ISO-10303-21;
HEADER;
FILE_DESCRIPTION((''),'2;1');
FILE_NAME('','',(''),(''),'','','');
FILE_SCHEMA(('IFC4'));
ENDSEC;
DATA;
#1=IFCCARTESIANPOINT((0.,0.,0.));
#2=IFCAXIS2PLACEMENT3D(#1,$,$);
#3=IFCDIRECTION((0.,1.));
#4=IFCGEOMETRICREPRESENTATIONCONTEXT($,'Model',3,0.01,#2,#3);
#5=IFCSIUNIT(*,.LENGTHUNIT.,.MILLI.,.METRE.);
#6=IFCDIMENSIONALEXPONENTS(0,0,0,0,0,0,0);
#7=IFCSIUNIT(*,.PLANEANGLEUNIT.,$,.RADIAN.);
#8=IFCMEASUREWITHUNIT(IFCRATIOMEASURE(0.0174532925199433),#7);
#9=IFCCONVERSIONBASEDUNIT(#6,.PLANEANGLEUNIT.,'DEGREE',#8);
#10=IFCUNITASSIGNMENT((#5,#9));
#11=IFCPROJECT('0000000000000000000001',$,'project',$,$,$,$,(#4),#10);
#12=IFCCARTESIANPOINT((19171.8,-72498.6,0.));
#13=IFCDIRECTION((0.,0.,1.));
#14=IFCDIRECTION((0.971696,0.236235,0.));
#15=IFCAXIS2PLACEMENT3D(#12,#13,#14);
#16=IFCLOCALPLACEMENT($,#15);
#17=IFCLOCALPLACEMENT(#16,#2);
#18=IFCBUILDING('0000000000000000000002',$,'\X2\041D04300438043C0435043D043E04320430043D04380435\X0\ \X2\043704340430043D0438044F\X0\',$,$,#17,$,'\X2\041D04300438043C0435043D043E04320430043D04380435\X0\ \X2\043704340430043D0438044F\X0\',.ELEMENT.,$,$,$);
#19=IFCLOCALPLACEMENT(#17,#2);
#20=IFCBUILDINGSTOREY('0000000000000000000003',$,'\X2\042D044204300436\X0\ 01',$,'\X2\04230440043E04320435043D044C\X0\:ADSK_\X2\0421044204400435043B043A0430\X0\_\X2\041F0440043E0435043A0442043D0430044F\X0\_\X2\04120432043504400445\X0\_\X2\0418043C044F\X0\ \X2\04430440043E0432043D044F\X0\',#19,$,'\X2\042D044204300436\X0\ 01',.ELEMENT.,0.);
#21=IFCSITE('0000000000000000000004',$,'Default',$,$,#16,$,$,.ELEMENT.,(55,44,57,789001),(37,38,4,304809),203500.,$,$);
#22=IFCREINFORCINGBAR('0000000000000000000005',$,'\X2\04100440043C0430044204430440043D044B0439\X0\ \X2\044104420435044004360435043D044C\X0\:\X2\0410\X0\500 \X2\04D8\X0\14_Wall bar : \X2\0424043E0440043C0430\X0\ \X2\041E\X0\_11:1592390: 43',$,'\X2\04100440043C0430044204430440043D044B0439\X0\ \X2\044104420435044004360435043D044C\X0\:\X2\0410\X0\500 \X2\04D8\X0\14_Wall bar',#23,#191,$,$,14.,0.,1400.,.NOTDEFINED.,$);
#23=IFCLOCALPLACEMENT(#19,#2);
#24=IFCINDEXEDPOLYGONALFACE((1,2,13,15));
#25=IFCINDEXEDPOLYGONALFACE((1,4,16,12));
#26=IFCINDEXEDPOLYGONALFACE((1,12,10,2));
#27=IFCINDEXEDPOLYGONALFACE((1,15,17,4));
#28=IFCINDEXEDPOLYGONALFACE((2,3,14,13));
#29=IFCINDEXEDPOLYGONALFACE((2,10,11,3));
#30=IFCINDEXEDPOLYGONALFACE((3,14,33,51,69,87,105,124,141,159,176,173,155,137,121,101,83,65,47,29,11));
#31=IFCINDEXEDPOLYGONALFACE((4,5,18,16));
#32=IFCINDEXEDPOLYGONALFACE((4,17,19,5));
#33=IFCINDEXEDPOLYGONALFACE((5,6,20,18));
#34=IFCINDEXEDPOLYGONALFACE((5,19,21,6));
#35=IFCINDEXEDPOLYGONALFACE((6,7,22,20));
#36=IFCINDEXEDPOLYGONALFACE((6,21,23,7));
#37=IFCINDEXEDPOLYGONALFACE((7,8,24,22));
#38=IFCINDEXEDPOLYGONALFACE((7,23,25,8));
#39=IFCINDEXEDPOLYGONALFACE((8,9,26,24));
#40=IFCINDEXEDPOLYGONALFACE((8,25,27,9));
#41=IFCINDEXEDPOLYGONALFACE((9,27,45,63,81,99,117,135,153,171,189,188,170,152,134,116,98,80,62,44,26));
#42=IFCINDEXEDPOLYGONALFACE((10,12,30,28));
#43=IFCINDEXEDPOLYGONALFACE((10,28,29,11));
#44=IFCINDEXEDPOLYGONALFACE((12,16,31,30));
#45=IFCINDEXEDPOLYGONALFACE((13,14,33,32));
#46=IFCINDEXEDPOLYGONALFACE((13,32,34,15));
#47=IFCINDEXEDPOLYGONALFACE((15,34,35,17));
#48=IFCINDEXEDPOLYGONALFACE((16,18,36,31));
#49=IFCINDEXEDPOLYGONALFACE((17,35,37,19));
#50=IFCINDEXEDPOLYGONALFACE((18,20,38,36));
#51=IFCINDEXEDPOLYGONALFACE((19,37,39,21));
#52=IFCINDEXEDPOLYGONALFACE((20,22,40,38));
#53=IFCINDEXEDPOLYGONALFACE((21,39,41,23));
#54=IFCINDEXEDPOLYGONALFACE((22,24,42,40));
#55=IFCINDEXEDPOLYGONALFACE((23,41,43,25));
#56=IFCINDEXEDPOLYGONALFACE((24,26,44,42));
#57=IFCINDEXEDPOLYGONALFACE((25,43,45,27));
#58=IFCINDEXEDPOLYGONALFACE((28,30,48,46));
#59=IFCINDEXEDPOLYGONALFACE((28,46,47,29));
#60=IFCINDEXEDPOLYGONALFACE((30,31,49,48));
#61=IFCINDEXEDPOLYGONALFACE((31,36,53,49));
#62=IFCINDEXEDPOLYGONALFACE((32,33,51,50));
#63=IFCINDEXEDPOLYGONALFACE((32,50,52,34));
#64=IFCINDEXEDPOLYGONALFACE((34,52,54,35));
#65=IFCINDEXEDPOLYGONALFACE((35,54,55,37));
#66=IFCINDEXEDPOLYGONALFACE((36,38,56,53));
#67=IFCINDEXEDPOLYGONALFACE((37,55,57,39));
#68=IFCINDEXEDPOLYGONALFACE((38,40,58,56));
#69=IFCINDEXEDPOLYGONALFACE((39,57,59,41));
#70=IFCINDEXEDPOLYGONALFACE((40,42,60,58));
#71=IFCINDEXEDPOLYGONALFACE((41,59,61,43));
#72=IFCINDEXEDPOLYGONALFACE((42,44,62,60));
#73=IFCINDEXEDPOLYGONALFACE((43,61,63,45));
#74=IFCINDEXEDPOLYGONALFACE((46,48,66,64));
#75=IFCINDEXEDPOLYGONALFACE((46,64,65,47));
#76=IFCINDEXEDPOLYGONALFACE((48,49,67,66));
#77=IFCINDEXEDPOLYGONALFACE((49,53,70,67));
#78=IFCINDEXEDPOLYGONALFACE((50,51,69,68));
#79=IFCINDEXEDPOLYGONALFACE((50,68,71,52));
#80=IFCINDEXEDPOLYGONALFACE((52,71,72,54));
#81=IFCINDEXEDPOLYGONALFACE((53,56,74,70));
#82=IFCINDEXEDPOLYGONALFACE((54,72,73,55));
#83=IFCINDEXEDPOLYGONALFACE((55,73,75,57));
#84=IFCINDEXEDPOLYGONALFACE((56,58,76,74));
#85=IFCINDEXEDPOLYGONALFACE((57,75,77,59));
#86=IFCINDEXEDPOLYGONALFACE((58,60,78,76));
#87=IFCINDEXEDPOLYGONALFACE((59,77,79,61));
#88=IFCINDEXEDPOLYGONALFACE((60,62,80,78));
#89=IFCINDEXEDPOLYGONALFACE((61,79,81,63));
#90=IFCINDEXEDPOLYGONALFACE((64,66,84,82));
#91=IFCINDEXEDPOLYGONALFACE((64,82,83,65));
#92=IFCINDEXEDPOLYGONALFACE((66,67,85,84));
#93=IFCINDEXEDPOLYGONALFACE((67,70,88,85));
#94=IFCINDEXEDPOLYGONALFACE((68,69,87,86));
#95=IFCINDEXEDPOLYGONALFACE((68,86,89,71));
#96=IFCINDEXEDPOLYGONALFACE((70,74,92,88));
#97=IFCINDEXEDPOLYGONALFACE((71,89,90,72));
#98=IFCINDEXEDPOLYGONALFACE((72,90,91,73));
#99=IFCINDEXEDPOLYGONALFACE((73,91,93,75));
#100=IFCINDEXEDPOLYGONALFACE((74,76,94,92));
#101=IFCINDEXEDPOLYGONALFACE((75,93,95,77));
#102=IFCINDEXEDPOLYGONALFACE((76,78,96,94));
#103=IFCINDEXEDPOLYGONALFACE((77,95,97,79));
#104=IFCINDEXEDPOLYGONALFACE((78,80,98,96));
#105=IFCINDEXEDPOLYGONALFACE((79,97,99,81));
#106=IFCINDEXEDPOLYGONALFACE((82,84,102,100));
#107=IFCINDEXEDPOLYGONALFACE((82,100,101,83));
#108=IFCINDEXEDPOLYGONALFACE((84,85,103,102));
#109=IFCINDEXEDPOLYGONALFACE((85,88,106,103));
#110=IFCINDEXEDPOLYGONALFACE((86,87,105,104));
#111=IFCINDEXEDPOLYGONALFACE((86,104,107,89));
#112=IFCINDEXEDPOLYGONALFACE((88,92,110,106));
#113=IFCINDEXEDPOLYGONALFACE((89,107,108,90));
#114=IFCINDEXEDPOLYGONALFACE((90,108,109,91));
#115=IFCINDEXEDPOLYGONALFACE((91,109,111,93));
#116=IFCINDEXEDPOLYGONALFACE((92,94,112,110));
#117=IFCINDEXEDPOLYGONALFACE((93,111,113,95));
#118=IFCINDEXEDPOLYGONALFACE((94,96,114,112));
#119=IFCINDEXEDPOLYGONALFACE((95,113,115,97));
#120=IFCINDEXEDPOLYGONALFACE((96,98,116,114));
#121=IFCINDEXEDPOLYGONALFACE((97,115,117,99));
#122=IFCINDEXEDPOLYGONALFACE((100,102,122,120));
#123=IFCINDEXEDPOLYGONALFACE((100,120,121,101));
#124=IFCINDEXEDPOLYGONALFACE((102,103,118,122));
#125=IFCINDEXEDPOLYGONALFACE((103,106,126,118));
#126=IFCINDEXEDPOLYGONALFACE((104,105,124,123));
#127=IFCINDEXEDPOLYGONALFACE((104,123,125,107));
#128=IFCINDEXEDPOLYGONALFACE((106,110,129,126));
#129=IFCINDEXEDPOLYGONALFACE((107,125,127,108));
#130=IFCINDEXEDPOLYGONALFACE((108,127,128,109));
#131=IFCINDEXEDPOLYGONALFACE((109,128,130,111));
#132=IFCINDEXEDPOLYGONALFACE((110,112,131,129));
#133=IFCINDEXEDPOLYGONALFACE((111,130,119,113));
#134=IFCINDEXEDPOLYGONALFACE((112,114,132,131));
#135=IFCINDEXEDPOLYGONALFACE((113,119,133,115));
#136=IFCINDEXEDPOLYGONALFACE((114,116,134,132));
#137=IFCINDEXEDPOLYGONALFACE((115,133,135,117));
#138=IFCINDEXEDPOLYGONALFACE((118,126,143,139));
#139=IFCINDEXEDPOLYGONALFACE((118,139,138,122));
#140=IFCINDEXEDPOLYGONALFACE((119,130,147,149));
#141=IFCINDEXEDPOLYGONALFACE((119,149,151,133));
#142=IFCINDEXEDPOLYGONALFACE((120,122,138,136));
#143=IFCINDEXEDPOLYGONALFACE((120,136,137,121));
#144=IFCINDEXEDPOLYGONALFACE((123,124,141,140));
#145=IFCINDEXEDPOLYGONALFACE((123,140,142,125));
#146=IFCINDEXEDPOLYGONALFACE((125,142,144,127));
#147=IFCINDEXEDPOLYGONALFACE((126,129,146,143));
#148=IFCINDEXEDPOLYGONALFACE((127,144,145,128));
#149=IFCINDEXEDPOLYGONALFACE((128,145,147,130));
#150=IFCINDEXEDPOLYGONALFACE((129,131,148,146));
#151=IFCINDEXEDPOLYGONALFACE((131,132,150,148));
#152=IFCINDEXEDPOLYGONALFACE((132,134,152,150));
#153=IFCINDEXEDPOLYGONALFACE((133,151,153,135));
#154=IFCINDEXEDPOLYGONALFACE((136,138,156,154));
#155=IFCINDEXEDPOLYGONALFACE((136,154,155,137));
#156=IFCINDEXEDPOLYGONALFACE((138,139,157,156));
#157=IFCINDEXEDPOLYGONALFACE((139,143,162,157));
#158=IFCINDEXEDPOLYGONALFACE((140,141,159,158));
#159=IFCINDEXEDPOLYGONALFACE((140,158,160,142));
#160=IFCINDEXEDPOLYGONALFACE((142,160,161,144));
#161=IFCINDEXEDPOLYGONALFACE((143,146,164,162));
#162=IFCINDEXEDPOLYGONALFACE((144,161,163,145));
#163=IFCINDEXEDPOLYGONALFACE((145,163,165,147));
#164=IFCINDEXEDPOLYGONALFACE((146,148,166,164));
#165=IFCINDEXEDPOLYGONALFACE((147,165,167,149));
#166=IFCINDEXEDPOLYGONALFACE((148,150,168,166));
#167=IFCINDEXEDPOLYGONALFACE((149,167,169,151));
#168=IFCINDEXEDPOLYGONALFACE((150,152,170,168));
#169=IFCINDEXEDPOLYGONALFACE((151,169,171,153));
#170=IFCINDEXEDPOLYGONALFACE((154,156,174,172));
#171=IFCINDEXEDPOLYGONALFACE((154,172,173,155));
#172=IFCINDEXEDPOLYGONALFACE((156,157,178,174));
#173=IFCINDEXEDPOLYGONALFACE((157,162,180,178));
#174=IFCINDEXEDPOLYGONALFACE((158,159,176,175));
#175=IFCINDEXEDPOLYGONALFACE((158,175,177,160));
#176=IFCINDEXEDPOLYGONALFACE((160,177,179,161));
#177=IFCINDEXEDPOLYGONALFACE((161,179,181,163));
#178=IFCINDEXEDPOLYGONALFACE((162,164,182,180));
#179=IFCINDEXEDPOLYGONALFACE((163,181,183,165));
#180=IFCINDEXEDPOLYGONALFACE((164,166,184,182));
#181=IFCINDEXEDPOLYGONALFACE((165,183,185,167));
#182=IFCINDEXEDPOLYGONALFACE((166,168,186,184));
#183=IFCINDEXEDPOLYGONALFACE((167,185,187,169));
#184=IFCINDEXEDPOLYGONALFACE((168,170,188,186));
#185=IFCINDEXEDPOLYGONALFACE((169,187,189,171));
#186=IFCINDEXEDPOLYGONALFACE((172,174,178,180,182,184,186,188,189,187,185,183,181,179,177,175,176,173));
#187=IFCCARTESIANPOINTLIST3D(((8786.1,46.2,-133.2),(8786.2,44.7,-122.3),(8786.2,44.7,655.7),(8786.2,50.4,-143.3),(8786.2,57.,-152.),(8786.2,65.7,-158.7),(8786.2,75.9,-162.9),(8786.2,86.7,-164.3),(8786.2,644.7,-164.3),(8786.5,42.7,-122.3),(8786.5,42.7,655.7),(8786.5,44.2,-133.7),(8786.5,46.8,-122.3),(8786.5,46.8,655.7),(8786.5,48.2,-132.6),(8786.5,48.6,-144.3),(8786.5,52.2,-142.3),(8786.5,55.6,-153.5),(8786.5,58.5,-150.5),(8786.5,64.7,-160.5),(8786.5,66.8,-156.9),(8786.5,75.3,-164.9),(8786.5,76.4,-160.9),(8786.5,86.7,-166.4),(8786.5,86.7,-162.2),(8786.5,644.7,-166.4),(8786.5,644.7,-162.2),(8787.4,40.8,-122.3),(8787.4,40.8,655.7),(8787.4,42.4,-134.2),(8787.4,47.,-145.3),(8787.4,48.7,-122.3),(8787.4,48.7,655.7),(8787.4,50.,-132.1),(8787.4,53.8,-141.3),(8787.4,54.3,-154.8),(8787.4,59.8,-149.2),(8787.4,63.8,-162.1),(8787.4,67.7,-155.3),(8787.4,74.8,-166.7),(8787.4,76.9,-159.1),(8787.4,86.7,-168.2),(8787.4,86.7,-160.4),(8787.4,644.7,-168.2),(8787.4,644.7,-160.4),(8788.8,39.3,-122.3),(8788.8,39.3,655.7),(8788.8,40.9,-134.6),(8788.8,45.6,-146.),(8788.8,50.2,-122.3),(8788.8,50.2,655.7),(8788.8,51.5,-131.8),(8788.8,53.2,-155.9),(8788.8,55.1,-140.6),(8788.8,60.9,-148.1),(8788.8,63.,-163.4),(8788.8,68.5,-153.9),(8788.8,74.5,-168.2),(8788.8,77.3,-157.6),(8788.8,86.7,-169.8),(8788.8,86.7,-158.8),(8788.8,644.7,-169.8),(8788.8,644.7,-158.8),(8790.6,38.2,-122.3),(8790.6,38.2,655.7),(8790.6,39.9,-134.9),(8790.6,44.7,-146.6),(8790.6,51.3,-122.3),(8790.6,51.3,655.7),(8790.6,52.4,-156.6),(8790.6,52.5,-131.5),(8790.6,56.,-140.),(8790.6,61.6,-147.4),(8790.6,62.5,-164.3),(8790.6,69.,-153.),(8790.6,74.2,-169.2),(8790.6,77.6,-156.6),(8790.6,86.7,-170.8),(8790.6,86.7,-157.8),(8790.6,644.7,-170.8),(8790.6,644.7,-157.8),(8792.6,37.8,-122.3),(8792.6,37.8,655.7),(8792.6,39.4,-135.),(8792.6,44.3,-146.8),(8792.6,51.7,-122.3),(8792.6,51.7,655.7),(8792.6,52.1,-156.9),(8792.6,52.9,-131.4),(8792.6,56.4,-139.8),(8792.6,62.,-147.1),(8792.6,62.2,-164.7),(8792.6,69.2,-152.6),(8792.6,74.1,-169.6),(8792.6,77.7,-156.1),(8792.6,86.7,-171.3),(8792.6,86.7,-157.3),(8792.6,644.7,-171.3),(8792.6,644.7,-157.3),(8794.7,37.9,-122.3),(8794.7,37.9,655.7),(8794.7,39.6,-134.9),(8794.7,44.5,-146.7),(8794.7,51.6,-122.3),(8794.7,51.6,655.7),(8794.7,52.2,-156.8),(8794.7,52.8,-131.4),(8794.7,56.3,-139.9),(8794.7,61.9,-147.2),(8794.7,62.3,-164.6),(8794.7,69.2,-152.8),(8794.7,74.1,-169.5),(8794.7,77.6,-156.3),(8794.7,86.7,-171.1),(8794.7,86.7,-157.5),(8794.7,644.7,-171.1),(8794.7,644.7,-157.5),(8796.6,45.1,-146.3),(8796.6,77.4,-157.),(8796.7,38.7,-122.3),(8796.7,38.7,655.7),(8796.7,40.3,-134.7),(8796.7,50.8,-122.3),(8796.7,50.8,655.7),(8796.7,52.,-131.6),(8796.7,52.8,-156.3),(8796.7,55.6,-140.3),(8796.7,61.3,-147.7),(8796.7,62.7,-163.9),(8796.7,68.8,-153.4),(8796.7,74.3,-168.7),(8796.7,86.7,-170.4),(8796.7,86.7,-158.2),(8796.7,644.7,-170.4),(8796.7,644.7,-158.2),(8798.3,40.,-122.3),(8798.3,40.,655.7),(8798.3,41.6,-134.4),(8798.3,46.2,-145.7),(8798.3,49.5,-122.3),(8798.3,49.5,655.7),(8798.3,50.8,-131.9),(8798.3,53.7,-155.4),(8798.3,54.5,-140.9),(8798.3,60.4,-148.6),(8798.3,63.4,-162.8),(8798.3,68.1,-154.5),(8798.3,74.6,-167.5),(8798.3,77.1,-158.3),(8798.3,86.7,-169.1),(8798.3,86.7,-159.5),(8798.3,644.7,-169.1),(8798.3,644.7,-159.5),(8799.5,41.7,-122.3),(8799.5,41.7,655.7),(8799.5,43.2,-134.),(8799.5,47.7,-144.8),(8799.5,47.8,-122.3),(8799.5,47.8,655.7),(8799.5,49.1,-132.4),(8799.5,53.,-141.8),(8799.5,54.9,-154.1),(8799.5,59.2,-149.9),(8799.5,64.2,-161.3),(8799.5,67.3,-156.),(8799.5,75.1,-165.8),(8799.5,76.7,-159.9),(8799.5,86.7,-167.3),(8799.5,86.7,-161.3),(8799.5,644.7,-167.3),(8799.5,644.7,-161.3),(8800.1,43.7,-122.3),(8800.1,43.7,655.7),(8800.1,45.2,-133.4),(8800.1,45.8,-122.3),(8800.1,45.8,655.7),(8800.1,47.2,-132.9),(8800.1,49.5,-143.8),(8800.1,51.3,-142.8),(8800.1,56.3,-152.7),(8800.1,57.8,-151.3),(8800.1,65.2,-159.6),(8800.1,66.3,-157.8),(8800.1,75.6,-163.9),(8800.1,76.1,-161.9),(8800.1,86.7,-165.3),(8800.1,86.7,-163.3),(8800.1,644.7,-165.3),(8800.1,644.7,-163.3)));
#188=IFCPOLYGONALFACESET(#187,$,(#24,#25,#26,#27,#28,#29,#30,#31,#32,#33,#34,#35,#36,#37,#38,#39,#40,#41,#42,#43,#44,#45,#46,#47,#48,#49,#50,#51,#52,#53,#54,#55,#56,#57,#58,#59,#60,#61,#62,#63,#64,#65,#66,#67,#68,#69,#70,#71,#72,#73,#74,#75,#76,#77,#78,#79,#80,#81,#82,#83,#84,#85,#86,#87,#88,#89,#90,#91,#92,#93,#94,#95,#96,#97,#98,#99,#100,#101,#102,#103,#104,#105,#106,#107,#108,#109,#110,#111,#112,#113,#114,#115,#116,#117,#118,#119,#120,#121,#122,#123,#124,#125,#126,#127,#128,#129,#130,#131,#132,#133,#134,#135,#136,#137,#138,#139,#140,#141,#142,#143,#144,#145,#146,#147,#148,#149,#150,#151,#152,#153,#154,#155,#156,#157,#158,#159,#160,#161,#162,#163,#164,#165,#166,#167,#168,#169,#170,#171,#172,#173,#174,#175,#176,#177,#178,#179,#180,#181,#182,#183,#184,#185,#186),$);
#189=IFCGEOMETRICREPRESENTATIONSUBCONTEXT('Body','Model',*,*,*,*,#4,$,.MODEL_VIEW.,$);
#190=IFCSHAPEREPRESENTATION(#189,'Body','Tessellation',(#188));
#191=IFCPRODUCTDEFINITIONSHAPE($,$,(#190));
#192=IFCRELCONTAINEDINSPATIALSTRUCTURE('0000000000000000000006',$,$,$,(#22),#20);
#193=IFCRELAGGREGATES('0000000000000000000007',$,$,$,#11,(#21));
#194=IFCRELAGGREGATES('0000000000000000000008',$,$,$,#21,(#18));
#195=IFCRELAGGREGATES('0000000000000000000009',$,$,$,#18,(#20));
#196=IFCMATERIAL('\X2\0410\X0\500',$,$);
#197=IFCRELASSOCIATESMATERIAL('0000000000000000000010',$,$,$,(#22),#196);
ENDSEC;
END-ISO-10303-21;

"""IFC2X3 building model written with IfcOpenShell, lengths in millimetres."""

from ifc_helpers import new_model, entity, si_unit, converted_unit, direction, frame, origin, place, context, subcontext, project, spatial, material, element, save


model = new_model("IFC2X3")

# Units and contexts
model_context = context("Model", 3, precision=0.01, world=origin(), true_north=direction((0.0, 1.0)))
body_context = subcontext(model_context, "Body", "Model", "MODEL_VIEW")
ifc_project = project(units=[si_unit("LENGTHUNIT", "METRE", prefix="MILLI"), converted_unit("PLANEANGLEUNIT", "DEGREE", entity("IfcRatioMeasure", 0.0174532925199433), si_unit("PLANEANGLEUNIT", "RADIAN"), dimensions=[0, 0, 0, 0, 0, 0, 0])], contexts=[model_context])

# Site, building, storey
site_placement = place(None, frame((19171.8, -72498.6, 0.0), z_axis=(0.0, 0.0, 1.0), x_axis=(0.971696, 0.236235, 0.0)))
site = spatial("IfcSite", under=ifc_project, at=site_placement, Name="Default", CompositionType="ELEMENT", RefLatitude=(55, 44, 57, 789001), RefLongitude=(37, 38, 4, 304809), RefElevation=203500.0)
building_placement = place(site_placement, origin())
building = spatial("IfcBuilding", under=site, at=building_placement, Name="Наименование здания", LongName="Наименование здания", CompositionType="ELEMENT")
storey_placement = place(building_placement, origin())
storey = spatial("IfcBuildingStorey", under=building, at=storey_placement, Name="Этаж 01", ObjectType="Уровень:ADSK_Стрелка_Проектная_Вверх_Имя уровня", LongName="Этаж 01", CompositionType="ELEMENT", Elevation=0.0)

# Reinforcing bar
ifc_material = material(Name="А500")
placement = place(storey_placement, origin())
element("IfcReinforcingBar", 1, at=placement, inside=storey, material=ifc_material, Name="Арматурный стержень:А500 Ә14_Wall bar : Форма О_11:1592390: 43", ObjectType="Арматурный стержень:А500 Ә14_Wall bar", BarLength=1400.0, BarRole="NOTDEFINED", CrossSectionArea=0.0, NominalDiameter=14.0, context=body_context, shape_type="AdvancedSweptSolid", body=[
    entity("IfcSweptDiskSolid", entity("IfcCompositeCurve", [entity("IfcCompositeCurveSegment", "CONTINUOUS", True, entity("IfcPolyline", [entity("IfcCartesianPoint", [8793.1, 44.7, 655.7]), entity("IfcCartesianPoint", [8793.1, 44.7, -122.3])])), entity("IfcCompositeCurveSegment", "CONTINUOUS", True, entity("IfcTrimmedCurve", entity("IfcCircle", entity("IfcAxis2Placement3D", entity("IfcCartesianPoint", [8793.1, 86.7, -122.3]), entity("IfcDirection", [1.0, 0.0, 0.0]), entity("IfcDirection", [0.0, 0.0, -1.0])), 42.0), [entity("IfcParameterValue", 270.0)], [entity("IfcParameterValue", 360.0)], True, "PARAMETER")), entity("IfcCompositeCurveSegment", "CONTINUOUS", True, entity("IfcPolyline", [entity("IfcCartesianPoint", [8793.1, 86.7, -164.3]), entity("IfcCartesianPoint", [8793.1, 644.7, -164.3])]))], False), 7.0, None, 0.0, 92.0),
])

save(model, "model.ifc")
